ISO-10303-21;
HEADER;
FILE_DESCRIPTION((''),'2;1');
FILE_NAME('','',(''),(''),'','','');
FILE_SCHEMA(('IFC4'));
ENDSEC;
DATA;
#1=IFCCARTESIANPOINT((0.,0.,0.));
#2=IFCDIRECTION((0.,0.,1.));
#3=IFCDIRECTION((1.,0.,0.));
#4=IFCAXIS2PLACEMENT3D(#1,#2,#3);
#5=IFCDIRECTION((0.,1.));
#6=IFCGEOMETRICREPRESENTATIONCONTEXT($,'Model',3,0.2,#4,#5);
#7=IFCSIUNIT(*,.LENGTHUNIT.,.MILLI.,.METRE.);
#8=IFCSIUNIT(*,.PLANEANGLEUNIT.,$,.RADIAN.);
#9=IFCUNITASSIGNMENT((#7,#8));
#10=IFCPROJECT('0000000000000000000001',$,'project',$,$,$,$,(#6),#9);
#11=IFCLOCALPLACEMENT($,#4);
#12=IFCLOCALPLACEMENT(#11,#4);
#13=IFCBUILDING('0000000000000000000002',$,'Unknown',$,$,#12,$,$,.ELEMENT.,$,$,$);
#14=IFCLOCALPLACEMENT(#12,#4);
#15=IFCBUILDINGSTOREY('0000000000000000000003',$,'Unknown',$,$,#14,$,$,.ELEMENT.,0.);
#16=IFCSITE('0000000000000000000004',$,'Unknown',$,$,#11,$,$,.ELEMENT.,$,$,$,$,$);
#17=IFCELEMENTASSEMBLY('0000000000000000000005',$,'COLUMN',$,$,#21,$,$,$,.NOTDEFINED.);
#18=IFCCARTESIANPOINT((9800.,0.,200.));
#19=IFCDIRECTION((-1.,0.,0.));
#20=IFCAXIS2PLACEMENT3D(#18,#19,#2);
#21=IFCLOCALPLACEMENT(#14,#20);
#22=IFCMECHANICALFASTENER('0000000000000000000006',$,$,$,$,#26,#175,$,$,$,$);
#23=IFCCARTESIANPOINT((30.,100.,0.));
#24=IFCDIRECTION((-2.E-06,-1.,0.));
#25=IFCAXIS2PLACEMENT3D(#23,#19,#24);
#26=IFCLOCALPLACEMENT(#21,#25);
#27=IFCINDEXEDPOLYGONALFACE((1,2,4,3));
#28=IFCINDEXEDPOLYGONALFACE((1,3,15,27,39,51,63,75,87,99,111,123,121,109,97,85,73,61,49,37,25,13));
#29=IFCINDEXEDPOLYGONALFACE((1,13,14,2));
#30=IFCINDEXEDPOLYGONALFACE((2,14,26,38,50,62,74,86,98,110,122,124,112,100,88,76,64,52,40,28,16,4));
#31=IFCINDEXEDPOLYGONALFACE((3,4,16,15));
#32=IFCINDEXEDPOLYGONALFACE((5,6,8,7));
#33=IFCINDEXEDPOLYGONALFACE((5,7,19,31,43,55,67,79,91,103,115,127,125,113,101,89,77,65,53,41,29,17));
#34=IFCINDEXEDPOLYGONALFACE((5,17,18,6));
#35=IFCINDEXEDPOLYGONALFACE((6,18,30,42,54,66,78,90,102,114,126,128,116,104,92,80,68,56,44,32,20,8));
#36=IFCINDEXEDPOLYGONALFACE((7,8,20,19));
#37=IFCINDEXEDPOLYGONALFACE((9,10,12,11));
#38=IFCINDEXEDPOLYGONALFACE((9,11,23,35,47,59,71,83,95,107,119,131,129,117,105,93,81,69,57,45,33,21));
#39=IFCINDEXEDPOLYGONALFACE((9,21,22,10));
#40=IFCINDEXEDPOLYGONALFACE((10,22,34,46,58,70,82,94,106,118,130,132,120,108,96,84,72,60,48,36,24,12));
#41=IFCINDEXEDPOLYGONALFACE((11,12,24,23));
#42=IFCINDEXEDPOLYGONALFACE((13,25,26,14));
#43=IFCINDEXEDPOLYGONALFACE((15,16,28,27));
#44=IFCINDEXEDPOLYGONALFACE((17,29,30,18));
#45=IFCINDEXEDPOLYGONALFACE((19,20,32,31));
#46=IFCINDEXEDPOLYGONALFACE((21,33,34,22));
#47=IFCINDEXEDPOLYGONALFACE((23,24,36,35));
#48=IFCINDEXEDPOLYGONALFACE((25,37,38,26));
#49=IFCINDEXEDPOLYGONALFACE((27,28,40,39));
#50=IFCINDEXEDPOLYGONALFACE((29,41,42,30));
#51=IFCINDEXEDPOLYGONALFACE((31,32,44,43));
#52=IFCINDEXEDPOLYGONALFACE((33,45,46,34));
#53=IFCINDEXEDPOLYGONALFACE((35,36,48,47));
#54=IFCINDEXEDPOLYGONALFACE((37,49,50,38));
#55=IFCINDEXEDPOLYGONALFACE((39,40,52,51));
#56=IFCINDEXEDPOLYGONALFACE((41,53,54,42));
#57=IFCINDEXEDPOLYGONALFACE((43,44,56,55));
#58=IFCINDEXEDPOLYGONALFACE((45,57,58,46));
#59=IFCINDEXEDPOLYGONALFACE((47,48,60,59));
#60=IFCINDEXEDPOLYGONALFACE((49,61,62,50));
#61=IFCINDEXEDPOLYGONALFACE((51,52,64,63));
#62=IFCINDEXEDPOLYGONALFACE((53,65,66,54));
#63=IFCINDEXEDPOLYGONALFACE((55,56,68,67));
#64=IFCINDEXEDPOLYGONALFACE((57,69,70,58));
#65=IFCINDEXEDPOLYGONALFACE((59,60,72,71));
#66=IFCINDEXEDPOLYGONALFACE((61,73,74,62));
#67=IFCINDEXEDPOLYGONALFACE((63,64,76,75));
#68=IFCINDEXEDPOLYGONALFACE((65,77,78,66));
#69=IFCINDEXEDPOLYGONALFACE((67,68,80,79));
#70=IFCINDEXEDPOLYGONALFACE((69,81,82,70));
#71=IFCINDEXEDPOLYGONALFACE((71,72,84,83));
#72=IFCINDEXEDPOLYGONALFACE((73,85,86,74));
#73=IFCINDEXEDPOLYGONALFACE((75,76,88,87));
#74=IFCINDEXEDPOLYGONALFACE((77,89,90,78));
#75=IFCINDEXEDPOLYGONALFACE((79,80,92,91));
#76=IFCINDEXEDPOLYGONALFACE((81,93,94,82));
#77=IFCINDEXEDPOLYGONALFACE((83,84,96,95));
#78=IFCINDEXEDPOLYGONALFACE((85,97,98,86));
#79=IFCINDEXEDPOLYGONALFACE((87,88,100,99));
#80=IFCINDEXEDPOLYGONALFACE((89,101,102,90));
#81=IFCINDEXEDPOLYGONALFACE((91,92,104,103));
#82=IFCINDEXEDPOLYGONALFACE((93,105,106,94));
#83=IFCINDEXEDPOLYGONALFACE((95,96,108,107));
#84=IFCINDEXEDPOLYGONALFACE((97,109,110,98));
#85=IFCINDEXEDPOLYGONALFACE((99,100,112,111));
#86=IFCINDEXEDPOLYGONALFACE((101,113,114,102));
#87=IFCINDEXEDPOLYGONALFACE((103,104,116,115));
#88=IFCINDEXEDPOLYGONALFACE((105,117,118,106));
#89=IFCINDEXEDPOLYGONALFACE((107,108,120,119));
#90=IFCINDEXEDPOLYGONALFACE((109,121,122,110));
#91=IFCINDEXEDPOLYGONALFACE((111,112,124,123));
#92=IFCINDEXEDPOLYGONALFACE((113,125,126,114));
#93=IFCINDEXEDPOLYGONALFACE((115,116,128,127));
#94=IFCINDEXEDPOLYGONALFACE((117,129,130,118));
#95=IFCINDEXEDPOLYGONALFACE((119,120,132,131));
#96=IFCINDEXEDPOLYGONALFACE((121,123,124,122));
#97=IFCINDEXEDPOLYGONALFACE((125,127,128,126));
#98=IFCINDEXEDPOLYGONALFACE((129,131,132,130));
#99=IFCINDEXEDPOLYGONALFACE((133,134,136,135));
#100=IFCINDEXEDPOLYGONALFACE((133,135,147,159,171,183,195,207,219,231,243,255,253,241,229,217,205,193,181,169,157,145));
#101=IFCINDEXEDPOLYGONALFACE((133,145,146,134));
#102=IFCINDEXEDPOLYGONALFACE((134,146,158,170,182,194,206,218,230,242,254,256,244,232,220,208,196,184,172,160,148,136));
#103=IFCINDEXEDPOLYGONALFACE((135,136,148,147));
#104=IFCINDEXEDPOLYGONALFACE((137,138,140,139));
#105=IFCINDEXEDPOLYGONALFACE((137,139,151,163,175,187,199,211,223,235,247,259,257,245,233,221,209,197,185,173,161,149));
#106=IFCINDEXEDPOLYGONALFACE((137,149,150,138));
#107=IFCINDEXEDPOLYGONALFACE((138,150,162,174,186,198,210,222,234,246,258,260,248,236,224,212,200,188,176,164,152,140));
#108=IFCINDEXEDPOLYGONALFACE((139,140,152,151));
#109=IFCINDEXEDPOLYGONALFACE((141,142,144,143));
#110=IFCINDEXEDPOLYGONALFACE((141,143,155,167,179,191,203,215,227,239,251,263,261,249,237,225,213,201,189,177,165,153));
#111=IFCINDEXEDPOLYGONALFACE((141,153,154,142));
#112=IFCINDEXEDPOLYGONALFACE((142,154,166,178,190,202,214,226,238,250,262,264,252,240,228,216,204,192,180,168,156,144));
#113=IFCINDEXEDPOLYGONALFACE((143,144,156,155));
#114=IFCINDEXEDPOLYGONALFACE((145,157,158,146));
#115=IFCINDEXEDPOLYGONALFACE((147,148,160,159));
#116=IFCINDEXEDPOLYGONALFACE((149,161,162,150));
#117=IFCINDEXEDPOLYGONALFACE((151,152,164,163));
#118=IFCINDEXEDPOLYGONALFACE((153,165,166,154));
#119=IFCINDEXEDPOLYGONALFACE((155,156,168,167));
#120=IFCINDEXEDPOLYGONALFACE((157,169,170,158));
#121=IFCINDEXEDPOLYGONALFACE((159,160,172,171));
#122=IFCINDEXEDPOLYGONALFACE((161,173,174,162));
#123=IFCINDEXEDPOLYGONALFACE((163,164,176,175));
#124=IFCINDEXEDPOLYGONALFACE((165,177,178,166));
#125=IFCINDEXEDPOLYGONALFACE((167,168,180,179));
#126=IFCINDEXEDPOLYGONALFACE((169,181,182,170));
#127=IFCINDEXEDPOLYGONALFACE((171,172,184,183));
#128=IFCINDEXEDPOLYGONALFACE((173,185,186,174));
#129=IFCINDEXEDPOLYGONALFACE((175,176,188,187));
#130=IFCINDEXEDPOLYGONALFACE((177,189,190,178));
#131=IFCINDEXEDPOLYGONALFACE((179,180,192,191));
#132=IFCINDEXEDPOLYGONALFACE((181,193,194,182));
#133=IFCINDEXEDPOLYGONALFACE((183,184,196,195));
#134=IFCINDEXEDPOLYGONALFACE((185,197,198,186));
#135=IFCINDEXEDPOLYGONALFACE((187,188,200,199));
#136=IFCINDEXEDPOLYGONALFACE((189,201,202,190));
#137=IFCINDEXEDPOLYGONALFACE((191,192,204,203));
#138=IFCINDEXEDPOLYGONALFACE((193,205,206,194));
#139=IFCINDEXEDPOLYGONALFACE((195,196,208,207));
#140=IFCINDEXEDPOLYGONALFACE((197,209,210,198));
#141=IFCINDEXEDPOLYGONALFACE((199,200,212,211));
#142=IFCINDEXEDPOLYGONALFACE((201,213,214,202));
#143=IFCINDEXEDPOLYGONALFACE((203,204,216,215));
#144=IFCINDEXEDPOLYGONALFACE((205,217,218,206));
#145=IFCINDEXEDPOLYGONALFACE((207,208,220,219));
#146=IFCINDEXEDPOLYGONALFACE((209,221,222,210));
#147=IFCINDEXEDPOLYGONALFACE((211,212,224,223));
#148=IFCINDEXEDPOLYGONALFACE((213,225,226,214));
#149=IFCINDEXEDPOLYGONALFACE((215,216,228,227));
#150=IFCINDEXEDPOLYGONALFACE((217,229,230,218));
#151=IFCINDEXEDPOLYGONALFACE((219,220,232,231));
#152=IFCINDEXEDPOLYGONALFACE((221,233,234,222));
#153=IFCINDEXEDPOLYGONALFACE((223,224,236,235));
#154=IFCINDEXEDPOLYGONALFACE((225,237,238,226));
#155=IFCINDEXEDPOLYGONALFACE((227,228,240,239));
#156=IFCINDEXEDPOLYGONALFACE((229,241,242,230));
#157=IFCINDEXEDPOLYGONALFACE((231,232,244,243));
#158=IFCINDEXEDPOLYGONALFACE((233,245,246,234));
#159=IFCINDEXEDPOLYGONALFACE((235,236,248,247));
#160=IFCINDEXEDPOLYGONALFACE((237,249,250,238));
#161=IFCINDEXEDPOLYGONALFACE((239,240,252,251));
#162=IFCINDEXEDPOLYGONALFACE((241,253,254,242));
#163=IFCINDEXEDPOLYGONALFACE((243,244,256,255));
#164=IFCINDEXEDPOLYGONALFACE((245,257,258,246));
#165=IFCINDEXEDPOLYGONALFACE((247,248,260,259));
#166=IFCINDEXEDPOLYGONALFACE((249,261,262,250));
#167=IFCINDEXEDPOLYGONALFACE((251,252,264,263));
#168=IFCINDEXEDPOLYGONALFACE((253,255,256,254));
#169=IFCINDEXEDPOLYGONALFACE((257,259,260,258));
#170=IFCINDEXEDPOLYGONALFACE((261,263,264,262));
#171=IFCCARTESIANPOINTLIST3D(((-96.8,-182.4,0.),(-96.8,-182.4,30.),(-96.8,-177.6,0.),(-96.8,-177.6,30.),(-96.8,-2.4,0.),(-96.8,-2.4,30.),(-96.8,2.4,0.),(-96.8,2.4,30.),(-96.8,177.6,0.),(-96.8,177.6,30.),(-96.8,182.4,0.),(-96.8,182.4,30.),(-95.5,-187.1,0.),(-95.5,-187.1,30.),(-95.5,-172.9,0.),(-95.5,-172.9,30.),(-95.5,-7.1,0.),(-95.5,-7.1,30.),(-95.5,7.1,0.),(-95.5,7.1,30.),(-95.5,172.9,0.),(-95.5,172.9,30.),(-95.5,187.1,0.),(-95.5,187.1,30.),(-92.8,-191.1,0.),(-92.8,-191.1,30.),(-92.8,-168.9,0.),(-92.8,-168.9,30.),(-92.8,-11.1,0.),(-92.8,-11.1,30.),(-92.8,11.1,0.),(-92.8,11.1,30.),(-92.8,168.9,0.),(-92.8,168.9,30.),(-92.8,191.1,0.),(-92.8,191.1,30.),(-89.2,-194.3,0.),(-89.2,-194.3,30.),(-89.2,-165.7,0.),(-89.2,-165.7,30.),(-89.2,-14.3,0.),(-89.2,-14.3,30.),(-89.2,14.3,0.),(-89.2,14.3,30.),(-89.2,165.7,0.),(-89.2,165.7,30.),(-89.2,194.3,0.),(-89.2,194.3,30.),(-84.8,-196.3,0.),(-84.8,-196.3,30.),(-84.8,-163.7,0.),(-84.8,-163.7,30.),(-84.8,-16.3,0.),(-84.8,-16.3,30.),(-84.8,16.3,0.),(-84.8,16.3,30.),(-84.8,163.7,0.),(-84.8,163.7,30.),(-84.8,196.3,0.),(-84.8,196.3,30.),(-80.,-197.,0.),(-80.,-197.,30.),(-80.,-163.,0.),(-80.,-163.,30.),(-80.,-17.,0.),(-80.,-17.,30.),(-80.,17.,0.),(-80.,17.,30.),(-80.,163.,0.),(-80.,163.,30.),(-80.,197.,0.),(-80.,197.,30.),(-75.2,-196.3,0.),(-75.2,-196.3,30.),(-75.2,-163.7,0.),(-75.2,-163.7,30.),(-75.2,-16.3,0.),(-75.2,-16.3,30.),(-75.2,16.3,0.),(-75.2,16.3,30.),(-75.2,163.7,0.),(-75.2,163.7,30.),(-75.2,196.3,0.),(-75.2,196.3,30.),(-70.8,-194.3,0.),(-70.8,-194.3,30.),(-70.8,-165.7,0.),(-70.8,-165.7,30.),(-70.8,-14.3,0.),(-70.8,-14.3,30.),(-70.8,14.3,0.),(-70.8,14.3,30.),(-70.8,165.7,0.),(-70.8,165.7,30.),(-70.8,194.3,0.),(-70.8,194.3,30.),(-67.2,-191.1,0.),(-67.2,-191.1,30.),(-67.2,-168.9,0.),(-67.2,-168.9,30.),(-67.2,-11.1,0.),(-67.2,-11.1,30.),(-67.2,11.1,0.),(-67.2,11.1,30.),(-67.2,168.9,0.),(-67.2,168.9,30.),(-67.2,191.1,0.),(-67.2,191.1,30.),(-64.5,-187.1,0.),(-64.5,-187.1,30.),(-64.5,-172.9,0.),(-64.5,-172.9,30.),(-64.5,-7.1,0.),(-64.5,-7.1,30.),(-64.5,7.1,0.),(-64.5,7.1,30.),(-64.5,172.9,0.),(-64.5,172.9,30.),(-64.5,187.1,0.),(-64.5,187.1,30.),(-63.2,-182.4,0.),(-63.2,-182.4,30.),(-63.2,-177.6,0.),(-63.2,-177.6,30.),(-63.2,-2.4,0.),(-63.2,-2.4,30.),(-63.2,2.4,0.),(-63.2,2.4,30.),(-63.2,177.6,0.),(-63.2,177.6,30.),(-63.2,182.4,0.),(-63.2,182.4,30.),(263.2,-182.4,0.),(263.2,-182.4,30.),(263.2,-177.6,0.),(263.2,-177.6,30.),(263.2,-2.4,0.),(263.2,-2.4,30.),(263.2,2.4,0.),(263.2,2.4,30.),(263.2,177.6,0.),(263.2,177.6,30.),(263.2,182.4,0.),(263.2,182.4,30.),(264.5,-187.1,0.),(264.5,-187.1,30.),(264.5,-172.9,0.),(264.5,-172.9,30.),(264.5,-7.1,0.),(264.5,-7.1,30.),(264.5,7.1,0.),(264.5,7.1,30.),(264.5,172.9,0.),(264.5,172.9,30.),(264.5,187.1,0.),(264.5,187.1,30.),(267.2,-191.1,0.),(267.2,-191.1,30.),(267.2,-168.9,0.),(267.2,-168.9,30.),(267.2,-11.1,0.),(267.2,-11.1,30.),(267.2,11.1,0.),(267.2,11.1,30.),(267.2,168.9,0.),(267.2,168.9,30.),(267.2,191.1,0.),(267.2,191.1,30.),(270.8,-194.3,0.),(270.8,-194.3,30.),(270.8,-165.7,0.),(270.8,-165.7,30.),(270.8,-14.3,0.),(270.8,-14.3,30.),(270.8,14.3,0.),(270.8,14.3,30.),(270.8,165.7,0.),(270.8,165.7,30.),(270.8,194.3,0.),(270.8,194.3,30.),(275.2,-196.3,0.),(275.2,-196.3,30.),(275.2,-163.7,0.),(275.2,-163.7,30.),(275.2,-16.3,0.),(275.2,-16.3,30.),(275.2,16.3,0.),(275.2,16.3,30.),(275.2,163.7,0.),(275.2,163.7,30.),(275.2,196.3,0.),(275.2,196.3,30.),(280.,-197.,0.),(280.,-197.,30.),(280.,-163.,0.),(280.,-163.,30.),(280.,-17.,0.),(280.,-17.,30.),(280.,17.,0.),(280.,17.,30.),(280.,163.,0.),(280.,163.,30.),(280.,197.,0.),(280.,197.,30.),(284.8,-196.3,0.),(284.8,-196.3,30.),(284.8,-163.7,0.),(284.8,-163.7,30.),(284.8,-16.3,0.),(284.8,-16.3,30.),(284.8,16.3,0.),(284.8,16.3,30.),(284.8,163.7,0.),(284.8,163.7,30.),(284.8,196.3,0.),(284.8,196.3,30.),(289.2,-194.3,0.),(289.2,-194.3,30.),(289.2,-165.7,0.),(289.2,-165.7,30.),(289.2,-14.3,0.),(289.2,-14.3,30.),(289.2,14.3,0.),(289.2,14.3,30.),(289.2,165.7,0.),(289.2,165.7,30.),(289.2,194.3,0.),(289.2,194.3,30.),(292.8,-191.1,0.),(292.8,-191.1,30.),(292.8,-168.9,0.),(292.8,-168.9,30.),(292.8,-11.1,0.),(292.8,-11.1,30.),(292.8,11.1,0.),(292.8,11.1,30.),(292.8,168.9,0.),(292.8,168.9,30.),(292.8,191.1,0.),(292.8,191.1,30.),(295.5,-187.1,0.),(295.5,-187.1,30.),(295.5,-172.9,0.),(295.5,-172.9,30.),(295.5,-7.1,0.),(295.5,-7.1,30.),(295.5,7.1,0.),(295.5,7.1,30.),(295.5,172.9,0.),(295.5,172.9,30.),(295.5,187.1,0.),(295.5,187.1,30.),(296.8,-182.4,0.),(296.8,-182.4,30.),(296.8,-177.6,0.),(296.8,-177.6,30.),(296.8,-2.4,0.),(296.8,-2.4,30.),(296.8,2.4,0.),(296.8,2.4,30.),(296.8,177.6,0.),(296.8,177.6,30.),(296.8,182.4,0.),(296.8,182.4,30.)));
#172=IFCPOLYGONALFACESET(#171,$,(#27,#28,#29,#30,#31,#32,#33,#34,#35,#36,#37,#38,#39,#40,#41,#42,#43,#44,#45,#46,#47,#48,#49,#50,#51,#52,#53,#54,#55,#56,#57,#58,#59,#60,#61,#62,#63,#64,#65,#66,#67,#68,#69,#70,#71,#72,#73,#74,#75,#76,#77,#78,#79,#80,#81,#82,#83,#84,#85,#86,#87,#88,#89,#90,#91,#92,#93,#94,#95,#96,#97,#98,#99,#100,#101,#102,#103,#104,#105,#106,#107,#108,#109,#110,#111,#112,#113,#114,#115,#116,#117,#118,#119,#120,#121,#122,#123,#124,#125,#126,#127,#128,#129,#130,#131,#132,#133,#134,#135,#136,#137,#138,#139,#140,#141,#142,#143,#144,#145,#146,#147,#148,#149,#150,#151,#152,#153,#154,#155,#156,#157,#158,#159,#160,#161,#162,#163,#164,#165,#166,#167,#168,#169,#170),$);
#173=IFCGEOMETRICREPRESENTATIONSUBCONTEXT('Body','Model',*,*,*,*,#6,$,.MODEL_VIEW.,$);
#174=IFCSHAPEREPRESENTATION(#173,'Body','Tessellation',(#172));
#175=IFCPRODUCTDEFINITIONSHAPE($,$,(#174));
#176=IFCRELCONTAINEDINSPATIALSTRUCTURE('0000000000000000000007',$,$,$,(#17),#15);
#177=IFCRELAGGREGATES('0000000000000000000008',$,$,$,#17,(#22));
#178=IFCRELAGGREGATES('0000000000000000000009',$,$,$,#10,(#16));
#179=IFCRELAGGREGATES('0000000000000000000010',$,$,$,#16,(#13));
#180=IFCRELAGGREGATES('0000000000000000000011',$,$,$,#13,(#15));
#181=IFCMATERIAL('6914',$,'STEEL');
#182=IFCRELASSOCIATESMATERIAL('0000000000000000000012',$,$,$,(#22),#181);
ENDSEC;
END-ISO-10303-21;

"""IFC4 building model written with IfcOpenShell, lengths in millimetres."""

from ifc_helpers import new_model, si_unit, direction, frame, origin_with_axes, place, context, subcontext, project, spatial, arc, indexed_curve, outline, extrude, source, transform, mapped, material, element, aggregate, save


model = new_model("IFC4")

# Units and contexts
model_context = context("Model", 3, precision=0.2, world=origin_with_axes(), true_north=direction((0.0, 1.0)))
body_context = subcontext(model_context, "Body", "Model", "MODEL_VIEW")
ifc_project = project(units=[si_unit("LENGTHUNIT", "METRE", prefix="MILLI"), si_unit("PLANEANGLEUNIT", "RADIAN")], contexts=[model_context])

# Site, building, storey
site_placement = place(None, origin_with_axes())
site = spatial("IfcSite", under=ifc_project, at=site_placement, Name="Unknown", CompositionType="ELEMENT")
building_placement = place(site_placement, origin_with_axes())
building = spatial("IfcBuilding", under=site, at=building_placement, Name="Unknown", CompositionType="ELEMENT")
storey_placement = place(building_placement, origin_with_axes())
storey = spatial("IfcBuildingStorey", under=building, at=storey_placement, Name="Unknown", CompositionType="ELEMENT", Elevation=0.0)

# Element assembly
assembly_1_placement = place(storey_placement, frame((9800.0, 0.0, 200.0), z_axis=(-1.0, 0.0, 0.0), x_axis=(0.0, 0.0, 1.0)))
assembly_1 = element("IfcElementAssembly", 1, at=assembly_1_placement, inside=storey, Name="COLUMN", PredefinedType="NOTDEFINED")

# Shared definitions
ifc_material_1 = material(Name="6914", Category="STEEL")

# Mechanical fastener
shared_shape_1 = source(origin_with_axes(), body_context, "Body", "SweptSolid", [
    extrude(outline(indexed_curve([(17.0, 0.0), (0.0, 17.0), (-17.0, 0.0), (0.0, -17.0)], segments=[arc(1, 2, 3), arc(3, 4, 1)])), frame((0.0, 0.0, 30.0), z_axis=(0.0, -0.000002, -1.0), x_axis=(0.0, 1.0, 0.0)), (0.0, 0.0, 1.0), 30.0),
])
mechanical_fastener_1_placement = place(assembly_1_placement, frame((30.0, 100.0, 0.0), z_axis=(-1.0, 0.0, 0.0), x_axis=(-0.000002, -1.0, 0.0)))
mechanical_fastener_1 = element("IfcMechanicalFastener", 2, at=mechanical_fastener_1_placement, material=ifc_material_1, context=body_context, shape_type="MappedRepresentation", body=[
    mapped(shared_shape_1, transform((-80.0, -180.0, 0.0))),
    mapped(shared_shape_1, transform((-80.0, 0.0, 0.0))),
    mapped(shared_shape_1, transform((-80.0, 180.0, 0.0))),
    mapped(shared_shape_1, transform((280.0, -180.0, 0.0))),
    mapped(shared_shape_1, transform((280.0, 0.0, 0.0))),
    mapped(shared_shape_1, transform((280.0, 180.0, 0.0))),
])
aggregate(assembly_1, [mechanical_fastener_1])

save(model, "model.ifc")
